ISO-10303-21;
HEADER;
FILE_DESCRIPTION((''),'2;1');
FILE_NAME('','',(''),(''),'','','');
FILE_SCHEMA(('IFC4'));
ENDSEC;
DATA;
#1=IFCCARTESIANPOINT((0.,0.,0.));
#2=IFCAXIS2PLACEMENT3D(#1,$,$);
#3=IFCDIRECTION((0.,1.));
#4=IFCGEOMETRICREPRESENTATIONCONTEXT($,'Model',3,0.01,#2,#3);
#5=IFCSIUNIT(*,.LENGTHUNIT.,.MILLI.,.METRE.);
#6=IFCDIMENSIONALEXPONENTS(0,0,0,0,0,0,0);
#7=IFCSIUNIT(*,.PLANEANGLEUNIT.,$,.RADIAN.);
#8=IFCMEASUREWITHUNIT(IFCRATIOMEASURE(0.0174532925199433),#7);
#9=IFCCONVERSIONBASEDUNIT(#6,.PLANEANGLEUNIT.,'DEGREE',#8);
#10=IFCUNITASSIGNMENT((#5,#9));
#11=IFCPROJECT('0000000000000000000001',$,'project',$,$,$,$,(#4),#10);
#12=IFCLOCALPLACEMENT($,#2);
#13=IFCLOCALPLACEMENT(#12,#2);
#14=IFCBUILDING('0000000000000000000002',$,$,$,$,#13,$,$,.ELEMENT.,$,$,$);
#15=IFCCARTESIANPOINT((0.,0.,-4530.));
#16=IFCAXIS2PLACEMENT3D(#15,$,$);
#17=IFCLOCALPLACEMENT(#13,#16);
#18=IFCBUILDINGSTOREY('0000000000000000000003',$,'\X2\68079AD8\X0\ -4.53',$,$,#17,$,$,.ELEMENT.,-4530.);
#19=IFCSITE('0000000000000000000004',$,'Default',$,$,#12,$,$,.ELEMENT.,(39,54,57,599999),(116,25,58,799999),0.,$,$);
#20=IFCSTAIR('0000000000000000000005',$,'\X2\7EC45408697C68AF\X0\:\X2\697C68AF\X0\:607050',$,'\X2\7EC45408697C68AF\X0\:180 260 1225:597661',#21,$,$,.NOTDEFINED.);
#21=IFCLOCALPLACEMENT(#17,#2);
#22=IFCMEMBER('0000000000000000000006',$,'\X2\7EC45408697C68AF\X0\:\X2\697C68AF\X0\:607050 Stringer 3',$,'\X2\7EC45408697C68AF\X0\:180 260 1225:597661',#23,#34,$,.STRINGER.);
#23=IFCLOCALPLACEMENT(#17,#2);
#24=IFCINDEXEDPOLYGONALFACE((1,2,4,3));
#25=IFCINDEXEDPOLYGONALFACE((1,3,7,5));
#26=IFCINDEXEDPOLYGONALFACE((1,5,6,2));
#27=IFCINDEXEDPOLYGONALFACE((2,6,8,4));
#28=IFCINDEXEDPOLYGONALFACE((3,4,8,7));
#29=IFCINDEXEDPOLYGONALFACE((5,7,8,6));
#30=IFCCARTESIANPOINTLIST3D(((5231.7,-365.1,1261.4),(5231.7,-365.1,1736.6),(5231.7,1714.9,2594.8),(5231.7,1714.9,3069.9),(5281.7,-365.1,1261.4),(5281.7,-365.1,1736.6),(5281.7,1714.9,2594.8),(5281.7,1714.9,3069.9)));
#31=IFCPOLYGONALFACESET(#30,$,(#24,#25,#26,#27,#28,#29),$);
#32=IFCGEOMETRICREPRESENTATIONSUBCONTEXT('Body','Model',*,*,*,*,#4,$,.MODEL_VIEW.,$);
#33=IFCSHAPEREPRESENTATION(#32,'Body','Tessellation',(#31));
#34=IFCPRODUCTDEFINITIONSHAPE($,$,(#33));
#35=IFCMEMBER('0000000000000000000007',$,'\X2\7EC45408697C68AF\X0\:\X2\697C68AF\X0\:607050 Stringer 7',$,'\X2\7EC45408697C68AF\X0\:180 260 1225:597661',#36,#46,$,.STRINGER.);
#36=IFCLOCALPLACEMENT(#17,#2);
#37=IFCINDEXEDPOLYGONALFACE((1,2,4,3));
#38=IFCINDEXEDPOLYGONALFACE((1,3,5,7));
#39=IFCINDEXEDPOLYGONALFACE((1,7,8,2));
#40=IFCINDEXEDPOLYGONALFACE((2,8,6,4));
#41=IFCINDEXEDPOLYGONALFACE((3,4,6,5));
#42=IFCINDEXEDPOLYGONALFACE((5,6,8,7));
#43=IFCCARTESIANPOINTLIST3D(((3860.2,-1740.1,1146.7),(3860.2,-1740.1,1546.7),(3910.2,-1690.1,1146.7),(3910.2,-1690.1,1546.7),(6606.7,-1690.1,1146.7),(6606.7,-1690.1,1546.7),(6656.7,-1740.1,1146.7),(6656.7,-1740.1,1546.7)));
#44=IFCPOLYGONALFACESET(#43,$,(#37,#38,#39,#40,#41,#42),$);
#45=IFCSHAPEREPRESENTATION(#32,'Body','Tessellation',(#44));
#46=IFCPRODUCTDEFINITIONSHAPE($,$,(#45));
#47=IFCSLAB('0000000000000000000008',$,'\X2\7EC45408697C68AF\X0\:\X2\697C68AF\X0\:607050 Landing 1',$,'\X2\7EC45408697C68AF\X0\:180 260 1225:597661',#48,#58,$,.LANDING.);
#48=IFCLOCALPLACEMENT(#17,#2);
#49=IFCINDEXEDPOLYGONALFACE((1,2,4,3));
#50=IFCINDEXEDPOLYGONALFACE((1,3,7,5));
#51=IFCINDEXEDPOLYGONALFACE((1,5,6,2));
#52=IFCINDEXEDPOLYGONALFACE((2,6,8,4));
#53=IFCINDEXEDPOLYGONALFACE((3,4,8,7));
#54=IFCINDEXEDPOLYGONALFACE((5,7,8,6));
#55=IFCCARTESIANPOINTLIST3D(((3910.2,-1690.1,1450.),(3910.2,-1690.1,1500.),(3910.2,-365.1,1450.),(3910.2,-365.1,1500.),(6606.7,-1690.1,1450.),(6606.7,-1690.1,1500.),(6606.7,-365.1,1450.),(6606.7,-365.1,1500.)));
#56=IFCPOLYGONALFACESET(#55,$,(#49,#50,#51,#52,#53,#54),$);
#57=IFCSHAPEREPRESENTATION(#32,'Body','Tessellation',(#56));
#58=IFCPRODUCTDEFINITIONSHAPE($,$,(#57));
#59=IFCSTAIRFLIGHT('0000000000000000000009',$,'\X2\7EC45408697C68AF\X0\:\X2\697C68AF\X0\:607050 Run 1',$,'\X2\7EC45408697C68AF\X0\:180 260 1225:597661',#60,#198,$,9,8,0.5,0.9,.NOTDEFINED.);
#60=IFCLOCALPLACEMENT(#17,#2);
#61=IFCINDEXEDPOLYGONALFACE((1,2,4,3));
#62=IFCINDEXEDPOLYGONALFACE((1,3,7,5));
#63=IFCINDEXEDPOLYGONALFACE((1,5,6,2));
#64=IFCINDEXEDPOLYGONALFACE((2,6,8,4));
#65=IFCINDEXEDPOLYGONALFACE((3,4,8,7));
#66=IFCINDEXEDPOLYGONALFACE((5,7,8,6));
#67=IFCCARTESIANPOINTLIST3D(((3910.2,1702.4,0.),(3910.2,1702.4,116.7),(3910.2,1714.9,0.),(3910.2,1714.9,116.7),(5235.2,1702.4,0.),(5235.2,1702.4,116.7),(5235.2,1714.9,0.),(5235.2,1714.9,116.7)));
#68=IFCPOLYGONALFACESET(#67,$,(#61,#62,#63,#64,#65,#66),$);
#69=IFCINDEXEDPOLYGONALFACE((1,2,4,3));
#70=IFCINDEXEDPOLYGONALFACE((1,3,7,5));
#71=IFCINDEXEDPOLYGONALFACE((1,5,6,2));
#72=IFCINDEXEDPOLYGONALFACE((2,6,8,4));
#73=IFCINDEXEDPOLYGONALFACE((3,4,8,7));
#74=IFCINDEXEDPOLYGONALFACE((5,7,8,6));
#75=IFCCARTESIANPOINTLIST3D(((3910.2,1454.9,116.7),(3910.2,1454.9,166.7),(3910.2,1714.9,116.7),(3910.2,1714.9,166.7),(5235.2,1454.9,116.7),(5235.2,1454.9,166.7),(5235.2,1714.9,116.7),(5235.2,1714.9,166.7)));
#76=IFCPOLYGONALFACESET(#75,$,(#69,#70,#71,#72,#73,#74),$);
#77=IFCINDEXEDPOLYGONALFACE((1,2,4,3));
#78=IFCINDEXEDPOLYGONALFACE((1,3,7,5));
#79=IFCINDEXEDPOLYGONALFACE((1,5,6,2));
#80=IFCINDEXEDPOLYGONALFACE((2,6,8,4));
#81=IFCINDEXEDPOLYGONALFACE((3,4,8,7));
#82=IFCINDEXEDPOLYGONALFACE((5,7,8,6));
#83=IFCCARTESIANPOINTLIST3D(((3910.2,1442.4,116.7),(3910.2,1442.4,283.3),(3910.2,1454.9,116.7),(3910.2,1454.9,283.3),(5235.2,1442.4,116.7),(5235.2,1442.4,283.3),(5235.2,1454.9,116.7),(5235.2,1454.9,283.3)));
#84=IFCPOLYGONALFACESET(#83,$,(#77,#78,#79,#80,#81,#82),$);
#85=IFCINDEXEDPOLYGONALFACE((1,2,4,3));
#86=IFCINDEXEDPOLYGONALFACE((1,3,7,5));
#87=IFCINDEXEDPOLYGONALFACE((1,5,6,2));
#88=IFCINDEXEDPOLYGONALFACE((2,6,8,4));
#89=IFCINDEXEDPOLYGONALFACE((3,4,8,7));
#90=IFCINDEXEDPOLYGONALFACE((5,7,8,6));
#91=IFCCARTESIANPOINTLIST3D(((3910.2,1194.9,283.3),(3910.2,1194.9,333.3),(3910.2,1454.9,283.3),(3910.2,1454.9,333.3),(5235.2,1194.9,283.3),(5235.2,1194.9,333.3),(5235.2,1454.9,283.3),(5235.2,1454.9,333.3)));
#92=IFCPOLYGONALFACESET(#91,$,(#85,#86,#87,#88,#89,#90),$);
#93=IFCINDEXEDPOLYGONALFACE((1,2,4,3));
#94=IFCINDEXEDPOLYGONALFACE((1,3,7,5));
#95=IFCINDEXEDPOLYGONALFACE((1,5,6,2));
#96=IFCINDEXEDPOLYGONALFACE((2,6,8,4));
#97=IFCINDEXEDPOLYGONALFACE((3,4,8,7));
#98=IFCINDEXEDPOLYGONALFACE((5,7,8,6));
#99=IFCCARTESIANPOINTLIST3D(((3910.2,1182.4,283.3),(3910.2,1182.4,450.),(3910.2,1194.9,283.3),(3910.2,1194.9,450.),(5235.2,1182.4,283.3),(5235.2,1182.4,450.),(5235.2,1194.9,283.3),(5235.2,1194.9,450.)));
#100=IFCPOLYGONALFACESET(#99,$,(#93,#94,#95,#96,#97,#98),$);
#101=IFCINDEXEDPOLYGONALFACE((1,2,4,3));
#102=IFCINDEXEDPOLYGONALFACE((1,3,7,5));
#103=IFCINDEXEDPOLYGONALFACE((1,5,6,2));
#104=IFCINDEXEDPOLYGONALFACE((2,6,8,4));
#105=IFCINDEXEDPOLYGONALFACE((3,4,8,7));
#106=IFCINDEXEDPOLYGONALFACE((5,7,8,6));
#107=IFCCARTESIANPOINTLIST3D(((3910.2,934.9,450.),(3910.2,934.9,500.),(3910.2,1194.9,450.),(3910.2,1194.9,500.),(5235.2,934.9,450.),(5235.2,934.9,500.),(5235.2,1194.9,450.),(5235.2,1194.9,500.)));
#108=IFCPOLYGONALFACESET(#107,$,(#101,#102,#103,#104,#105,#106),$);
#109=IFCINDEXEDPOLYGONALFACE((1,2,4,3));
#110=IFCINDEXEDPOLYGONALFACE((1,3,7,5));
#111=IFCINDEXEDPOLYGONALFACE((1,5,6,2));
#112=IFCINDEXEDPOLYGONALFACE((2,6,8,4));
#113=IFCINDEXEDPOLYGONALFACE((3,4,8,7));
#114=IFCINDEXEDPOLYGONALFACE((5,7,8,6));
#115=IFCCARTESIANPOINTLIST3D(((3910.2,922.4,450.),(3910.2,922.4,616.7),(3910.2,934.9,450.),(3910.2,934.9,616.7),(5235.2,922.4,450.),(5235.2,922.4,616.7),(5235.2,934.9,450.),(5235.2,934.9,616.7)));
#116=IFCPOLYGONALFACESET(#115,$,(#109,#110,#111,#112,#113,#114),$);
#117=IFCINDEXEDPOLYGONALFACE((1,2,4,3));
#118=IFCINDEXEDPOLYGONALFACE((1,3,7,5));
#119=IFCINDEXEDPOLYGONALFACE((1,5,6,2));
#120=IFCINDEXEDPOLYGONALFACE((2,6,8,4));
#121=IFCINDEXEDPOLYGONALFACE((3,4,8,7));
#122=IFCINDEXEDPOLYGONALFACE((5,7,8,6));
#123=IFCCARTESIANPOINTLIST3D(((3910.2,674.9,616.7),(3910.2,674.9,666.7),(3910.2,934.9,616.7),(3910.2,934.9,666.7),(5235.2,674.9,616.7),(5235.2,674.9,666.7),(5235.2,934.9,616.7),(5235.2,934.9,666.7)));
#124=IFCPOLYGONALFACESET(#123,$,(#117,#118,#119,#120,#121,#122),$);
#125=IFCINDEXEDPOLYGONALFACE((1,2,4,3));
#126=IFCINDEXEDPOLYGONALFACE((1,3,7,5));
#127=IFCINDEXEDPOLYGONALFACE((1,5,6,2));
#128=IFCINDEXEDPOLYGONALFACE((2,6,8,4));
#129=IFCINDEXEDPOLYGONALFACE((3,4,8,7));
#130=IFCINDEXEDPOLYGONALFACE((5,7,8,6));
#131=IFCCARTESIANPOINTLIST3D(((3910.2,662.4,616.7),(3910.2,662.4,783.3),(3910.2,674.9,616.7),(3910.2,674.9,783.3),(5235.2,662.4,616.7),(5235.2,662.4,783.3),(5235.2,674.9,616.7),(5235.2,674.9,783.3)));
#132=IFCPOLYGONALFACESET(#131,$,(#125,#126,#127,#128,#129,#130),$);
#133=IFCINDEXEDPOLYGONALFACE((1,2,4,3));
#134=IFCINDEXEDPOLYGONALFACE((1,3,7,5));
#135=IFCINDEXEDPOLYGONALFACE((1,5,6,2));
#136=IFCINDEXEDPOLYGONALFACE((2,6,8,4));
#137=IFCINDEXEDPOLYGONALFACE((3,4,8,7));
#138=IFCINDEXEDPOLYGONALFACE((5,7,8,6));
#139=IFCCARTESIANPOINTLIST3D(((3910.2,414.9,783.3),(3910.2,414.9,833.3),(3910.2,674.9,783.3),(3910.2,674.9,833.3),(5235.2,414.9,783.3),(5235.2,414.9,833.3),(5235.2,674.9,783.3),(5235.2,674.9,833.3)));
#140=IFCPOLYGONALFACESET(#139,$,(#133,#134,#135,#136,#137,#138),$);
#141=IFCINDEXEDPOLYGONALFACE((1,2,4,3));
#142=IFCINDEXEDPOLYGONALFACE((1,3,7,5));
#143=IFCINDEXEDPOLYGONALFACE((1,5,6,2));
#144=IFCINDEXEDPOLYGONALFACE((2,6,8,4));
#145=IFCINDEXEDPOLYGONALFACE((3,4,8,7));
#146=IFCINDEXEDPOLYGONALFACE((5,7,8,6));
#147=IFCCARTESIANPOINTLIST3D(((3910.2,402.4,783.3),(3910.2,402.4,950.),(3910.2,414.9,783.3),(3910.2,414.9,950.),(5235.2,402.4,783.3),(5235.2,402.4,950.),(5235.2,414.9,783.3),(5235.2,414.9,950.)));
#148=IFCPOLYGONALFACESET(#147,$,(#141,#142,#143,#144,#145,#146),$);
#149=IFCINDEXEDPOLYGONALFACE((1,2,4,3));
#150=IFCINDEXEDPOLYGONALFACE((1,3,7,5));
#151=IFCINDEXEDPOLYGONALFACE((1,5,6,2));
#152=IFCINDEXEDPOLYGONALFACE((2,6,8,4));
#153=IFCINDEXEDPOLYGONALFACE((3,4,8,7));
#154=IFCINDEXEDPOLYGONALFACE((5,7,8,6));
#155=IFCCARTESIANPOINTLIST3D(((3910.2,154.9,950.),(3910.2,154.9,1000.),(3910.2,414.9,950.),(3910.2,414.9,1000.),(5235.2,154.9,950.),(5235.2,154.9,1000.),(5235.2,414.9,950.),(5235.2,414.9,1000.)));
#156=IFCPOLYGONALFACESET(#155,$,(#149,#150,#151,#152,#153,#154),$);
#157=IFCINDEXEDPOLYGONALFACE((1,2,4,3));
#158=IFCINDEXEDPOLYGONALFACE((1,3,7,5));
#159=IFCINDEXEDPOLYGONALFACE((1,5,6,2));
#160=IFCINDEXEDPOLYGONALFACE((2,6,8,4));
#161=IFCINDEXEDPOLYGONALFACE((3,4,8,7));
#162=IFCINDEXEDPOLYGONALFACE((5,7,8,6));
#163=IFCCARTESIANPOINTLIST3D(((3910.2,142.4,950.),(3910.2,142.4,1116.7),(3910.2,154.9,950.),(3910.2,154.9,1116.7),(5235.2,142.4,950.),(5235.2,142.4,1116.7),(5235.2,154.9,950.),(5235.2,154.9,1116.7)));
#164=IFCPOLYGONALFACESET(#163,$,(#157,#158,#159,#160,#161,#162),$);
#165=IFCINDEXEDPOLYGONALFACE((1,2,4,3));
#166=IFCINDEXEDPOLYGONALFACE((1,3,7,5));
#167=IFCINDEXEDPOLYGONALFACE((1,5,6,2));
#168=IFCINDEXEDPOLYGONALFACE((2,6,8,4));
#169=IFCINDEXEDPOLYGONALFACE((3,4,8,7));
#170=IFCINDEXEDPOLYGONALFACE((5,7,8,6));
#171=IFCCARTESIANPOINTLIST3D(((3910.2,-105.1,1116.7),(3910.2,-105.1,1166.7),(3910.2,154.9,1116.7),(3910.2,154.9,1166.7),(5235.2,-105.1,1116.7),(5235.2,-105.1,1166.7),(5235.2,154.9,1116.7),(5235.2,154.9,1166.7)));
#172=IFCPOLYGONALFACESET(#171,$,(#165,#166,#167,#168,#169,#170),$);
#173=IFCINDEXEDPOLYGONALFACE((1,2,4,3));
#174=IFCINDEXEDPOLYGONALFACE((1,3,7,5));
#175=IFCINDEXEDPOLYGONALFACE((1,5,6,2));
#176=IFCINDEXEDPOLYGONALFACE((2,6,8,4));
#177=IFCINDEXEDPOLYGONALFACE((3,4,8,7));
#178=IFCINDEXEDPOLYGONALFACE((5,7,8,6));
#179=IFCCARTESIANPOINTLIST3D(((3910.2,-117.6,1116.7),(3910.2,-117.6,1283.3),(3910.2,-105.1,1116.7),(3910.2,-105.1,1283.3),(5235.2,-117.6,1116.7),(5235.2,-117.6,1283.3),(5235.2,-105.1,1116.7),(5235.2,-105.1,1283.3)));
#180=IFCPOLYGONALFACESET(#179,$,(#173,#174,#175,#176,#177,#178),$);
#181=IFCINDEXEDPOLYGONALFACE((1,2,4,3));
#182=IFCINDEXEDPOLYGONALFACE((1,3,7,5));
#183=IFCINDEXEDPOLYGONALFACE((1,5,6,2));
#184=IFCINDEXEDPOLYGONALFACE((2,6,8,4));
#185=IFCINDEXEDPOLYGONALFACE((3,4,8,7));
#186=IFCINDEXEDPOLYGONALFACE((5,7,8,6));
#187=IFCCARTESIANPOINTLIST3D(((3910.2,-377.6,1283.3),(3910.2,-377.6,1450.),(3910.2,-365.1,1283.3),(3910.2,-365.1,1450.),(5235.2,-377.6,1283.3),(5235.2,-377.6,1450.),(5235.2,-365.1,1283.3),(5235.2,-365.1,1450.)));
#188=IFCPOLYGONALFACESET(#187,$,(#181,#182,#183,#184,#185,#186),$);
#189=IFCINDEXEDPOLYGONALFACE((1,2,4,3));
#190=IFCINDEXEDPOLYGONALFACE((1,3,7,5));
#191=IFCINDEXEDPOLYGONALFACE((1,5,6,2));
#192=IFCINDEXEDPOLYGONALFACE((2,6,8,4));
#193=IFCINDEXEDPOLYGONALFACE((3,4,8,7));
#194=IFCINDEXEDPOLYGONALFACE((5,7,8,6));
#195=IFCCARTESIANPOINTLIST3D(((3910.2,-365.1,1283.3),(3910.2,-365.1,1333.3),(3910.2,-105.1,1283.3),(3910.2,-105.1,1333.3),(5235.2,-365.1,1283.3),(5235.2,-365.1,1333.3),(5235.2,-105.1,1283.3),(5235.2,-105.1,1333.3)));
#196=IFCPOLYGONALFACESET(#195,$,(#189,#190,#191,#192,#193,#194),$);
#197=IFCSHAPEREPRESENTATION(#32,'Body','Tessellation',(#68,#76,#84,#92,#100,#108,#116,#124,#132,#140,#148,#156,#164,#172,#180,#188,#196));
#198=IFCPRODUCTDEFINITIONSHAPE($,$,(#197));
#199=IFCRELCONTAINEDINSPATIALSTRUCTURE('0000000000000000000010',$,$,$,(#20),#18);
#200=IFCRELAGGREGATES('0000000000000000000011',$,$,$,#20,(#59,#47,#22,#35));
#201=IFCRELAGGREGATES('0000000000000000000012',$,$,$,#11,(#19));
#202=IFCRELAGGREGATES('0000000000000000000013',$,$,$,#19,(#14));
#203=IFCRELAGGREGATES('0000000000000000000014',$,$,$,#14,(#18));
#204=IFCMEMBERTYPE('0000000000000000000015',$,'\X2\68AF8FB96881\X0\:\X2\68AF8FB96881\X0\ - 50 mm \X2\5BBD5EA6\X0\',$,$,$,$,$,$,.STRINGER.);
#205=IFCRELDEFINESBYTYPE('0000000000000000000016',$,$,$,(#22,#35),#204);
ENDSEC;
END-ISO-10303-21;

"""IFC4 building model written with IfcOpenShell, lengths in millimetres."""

from ifc_helpers import new_model, entity, si_unit, converted_unit, direction, frame, frame_2d, origin, origin_2d_with_axis, place, context, subcontext, project, spatial, polyline, rectangle, outline, extrude, type_object, element, aggregate, save


model = new_model("IFC4")

# Units and contexts
model_context = context("Model", 3, precision=0.01, world=origin(), true_north=direction((0.0, 1.0)))
body_context = subcontext(model_context, "Body", "Model", "MODEL_VIEW")
ifc_project = project(units=[si_unit("LENGTHUNIT", "METRE", prefix="MILLI"), converted_unit("PLANEANGLEUNIT", "DEGREE", entity("IfcRatioMeasure", 0.0174532925199433), si_unit("PLANEANGLEUNIT", "RADIAN"), dimensions=[0, 0, 0, 0, 0, 0, 0])], contexts=[model_context])

# Site, building, storey
site_placement = place(None, origin())
site = spatial("IfcSite", under=ifc_project, at=site_placement, Name="Default", CompositionType="ELEMENT", RefLatitude=(39, 54, 57, 599999), RefLongitude=(116, 25, 58, 799999), RefElevation=0.0)
building_placement = place(site_placement, origin())
building = spatial("IfcBuilding", under=site, at=building_placement, CompositionType="ELEMENT")
storey_placement = place(building_placement, frame((0.0, 0.0, -4530.0)))
storey = spatial("IfcBuildingStorey", under=building, at=storey_placement, Name="标高 -4.53", CompositionType="ELEMENT", Elevation=-4530.0)

# Stair, members, slab, stair flight
stair_placement = place(storey_placement, origin())
stair = element("IfcStair", 1, at=stair_placement, inside=storey, Name="组合楼梯:楼梯:607050", ObjectType="组合楼梯:180 260 1225:597661", PredefinedType="NOTDEFINED")
member_type = type_object("IfcMemberType", Name="梯边梁:梯边梁 - 50 mm 宽度", PredefinedType="STRINGER")
member_1_placement = place(stair_placement, frame((5231.7, -365.1, 1261.4)))
member_1 = element("IfcMember", 2, at=member_1_placement, type_object=member_type, Name="组合楼梯:楼梯:607050 Stringer 3", ObjectType="组合楼梯:180 260 1225:597661", PredefinedType="STRINGER", context=body_context, shape_type="SweptSolid", body=[
    extrude(outline(polyline([(-1363.5, -200.0), (1107.1, -200.0), (1363.5, 200.0), (-1107.1, 200.0), (-1363.5, -200.0)])), frame((0.0, 1040.0, 904.2), z_axis=(1.0, 0.0, 0.0), x_axis=(0.0, 0.841879, 0.539666)), (0.0, 0.0, 1.0), 50.0),
])
member_2_placement = place(stair_placement, frame((3860.2, -1740.1, 1146.7)))
member_2 = element("IfcMember", 3, at=member_2_placement, type_object=member_type, Name="组合楼梯:楼梯:607050 Stringer 7", ObjectType="组合楼梯:180 260 1225:597661", PredefinedType="STRINGER", context=body_context, shape_type="SweptSolid", body=[
    extrude(outline(polyline([(-1398.3, -25.0), (1398.3, -25.0), (1348.3, 25.0), (-1348.3, 25.0), (-1398.3, -25.0)])), frame((1398.3, 25.0, 0.0)), (0.0, 0.0, 1.0), 400.0),
])
slab_placement = place(stair_placement, frame((3910.2, -1690.1, 0.0)))
slab = element("IfcSlab", 4, at=slab_placement, Name="组合楼梯:楼梯:607050 Landing 1", ObjectType="组合楼梯:180 260 1225:597661", PredefinedType="LANDING", context=body_context, shape_type="SweptSolid", body=[
    extrude(rectangle(XDim=2696.6, YDim=1325.0, at=frame_2d((0.0, 220.8), x_axis=(1.0, 0.0))), frame((1348.3, 883.3, 1450.0), z_axis=(0.0, 0.0, 1.0), x_axis=(-1.0, 0.0, 0.0)), (0.0, 0.0, 1.0), 50.0),
])
stair_flight_1_placement = place(stair_placement, frame((3910.2, -377.6, 0.0)))
stair_flight_1 = element("IfcStairFlight", 5, at=stair_flight_1_placement, Name="组合楼梯:楼梯:607050 Run 1", ObjectType="组合楼梯:180 260 1225:597661", NumberOfRisers=9, NumberOfTreads=8, PredefinedType="NOTDEFINED", RiserHeight=0.5, TreadLength=0.9, context=body_context, shape_type="SweptSolid", body=[
    extrude(rectangle(XDim=1325.0, YDim=12.5, at=frame_2d((0.0, 0.0), x_axis=(1.0, 0.0))), frame((662.5, 2086.2, 0.0)), (0.0, 0.0, 1.0), 116.7),
    extrude(rectangle(XDim=260.0, YDim=1325.0, at=frame_2d((0.0, 0.0), x_axis=(1.0, 0.0))), frame((662.5, 1962.5, 116.7), z_axis=(0.0, 0.0, 1.0), x_axis=(0.0, 1.0, 0.0)), (0.0, 0.0, 1.0), 50.0),
    extrude(rectangle(XDim=1325.0, YDim=12.5, at=frame_2d((0.0, 0.0), x_axis=(1.0, 0.0))), frame((662.5, 1826.2, 116.7)), (0.0, 0.0, 1.0), 166.7),
    extrude(rectangle(XDim=260.0, YDim=1325.0, at=frame_2d((0.0, 0.0), x_axis=(1.0, 0.0))), frame((662.5, 1702.5, 283.3), z_axis=(0.0, 0.0, 1.0), x_axis=(0.0, 1.0, 0.0)), (0.0, 0.0, 1.0), 50.0),
    extrude(rectangle(XDim=1325.0, YDim=12.5, at=frame_2d((0.0, 0.0), x_axis=(1.0, 0.0))), frame((662.5, 1566.2, 283.3)), (0.0, 0.0, 1.0), 166.7),
    extrude(rectangle(XDim=260.0, YDim=1325.0, at=frame_2d((0.0, 0.0), x_axis=(1.0, 0.0))), frame((662.5, 1442.5, 450.0), z_axis=(0.0, 0.0, 1.0), x_axis=(0.0, 1.0, 0.0)), (0.0, 0.0, 1.0), 50.0),
    extrude(rectangle(XDim=1325.0, YDim=12.5, at=frame_2d((0.0, 0.0), x_axis=(1.0, 0.0))), frame((662.5, 1306.2, 450.0)), (0.0, 0.0, 1.0), 166.7),
    extrude(rectangle(XDim=260.0, YDim=1325.0, at=frame_2d((0.0, 0.0), x_axis=(1.0, 0.0))), frame((662.5, 1182.5, 616.7), z_axis=(0.0, 0.0, 1.0), x_axis=(0.0, 1.0, 0.0)), (0.0, 0.0, 1.0), 50.0),
    extrude(rectangle(XDim=1325.0, YDim=12.5, at=frame_2d((0.0, 0.0), x_axis=(1.0, 0.0))), frame((662.5, 1046.2, 616.7)), (0.0, 0.0, 1.0), 166.7),
    extrude(rectangle(XDim=260.0, YDim=1325.0, at=frame_2d((0.0, 0.0), x_axis=(1.0, 0.0))), frame((662.5, 922.5, 783.3), z_axis=(0.0, 0.0, 1.0), x_axis=(0.0, 1.0, 0.0)), (0.0, 0.0, 1.0), 50.0),
    extrude(rectangle(XDim=1325.0, YDim=12.5, at=frame_2d((0.0, 0.0), x_axis=(1.0, 0.0))), frame((662.5, 786.3, 783.3)), (0.0, 0.0, 1.0), 166.7),
    extrude(rectangle(XDim=260.0, YDim=1325.0, at=frame_2d((0.0, 0.0), x_axis=(1.0, 0.0))), frame((662.5, 662.5, 950.0), z_axis=(0.0, 0.0, 1.0), x_axis=(0.0, 1.0, 0.0)), (0.0, 0.0, 1.0), 50.0),
    extrude(rectangle(XDim=1325.0, YDim=12.5, at=frame_2d((0.0, 0.0), x_axis=(1.0, 0.0))), frame((662.5, 526.2, 950.0)), (0.0, 0.0, 1.0), 166.7),
    extrude(rectangle(XDim=260.0, YDim=1325.0, at=frame_2d((0.0, 0.0), x_axis=(1.0, 0.0))), frame((662.5, 402.5, 1116.7), z_axis=(0.0, 0.0, 1.0), x_axis=(0.0, 1.0, 0.0)), (0.0, 0.0, 1.0), 50.0),
    extrude(rectangle(XDim=1325.0, YDim=12.5, at=frame_2d((0.0, 0.0), x_axis=(1.0, 0.0))), frame((662.5, 266.3, 1116.7)), (0.0, 0.0, 1.0), 166.7),
    extrude(rectangle(XDim=1325.0, YDim=12.5, at=origin_2d_with_axis()), frame((662.5, 6.2, 1283.3)), (0.0, 0.0, 1.0), 166.7),
    extrude(rectangle(XDim=260.0, YDim=1325.0, at=frame_2d((0.0, 0.0), x_axis=(1.0, 0.0))), frame((662.5, 142.5, 1283.3), z_axis=(0.0, 0.0, 1.0), x_axis=(0.0, 1.0, 0.0)), (0.0, 0.0, 1.0), 50.0),
])
aggregate(stair, [stair_flight_1, slab, member_1, member_2])

save(model, "model.ifc")
